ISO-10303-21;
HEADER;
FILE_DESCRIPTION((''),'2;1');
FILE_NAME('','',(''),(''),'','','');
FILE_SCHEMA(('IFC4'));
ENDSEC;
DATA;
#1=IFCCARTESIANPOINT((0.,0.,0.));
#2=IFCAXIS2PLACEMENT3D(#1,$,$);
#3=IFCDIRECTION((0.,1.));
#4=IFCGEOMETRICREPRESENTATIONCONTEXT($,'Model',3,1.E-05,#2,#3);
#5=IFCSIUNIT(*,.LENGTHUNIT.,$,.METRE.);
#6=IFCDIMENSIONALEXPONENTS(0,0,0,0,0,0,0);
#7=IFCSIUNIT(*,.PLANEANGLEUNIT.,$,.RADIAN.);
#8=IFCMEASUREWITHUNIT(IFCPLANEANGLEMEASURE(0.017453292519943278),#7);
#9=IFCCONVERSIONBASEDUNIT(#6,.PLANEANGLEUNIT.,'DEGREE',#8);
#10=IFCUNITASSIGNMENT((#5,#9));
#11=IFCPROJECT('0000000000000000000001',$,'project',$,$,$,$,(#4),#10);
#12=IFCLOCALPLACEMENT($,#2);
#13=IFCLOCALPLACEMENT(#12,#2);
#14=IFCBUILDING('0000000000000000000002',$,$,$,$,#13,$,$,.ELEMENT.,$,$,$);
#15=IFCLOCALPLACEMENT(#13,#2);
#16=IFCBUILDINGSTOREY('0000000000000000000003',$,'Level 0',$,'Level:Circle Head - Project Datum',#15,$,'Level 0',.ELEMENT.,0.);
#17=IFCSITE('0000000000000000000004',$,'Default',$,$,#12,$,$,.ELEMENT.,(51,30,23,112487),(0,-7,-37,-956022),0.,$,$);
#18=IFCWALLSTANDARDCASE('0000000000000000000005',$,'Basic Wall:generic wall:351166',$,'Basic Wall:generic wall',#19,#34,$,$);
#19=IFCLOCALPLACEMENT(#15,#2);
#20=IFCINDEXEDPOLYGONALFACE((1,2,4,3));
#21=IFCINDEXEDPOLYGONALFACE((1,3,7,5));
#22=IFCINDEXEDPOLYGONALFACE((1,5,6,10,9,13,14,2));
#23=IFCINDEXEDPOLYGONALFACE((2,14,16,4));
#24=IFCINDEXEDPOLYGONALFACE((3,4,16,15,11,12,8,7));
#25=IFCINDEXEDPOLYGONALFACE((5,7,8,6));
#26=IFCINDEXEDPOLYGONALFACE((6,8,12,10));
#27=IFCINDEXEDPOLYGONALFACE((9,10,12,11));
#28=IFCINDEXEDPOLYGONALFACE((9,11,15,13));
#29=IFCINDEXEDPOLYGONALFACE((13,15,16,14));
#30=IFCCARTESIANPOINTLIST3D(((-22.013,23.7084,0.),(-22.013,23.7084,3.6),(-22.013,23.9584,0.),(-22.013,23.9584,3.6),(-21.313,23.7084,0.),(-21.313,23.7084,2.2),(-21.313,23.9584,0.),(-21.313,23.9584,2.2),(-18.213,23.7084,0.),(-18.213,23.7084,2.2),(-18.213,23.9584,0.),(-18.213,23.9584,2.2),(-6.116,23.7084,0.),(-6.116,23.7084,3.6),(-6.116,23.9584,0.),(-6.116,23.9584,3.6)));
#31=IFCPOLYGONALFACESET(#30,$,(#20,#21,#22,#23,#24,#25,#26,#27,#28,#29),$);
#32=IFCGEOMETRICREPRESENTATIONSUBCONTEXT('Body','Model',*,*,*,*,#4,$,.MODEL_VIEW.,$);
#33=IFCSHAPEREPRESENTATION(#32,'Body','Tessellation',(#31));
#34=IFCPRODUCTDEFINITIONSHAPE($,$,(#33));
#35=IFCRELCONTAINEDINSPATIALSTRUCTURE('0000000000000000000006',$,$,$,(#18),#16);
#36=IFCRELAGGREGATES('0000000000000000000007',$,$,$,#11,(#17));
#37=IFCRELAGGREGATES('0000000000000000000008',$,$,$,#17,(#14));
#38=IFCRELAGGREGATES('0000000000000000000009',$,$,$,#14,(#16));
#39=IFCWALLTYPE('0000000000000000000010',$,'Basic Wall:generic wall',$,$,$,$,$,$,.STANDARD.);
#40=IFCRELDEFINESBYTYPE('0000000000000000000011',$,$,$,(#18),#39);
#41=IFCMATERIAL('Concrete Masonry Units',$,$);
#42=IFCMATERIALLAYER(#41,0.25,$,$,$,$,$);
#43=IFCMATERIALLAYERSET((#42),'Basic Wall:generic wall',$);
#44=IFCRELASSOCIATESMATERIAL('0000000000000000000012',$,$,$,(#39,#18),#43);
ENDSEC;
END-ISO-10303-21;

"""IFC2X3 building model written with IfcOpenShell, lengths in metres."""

from ifc_helpers import new_model, entity, si_unit, converted_unit, direction, frame, frame_2d, origin, place, context, subcontext, project, spatial, rectangle, extrude, material, layer, layer_set, layer_usage, type_object, element, save


model = new_model("IFC2X3")

# Units and contexts
model_context = context("Model", 3, precision=1e-05, world=origin(), true_north=direction((0.0, 1.0)))
body_context = subcontext(model_context, "Body", "Model", "MODEL_VIEW")
ifc_project = project(units=[si_unit("LENGTHUNIT", "METRE"), converted_unit("PLANEANGLEUNIT", "DEGREE", entity("IfcPlaneAngleMeasure", 0.017453292519943278), si_unit("PLANEANGLEUNIT", "RADIAN"), dimensions=[0, 0, 0, 0, 0, 0, 0])], contexts=[model_context])

# Site, building, storey
site_placement = place(None, origin())
site = spatial("IfcSite", under=ifc_project, at=site_placement, Name="Default", CompositionType="ELEMENT", RefLatitude=(51, 30, 23, 112487), RefLongitude=(0, -7, -37, -956022), RefElevation=0.0)
building_placement = place(site_placement, origin())
building = spatial("IfcBuilding", under=site, at=building_placement, CompositionType="ELEMENT")
storey_placement = place(building_placement, origin())
storey = spatial("IfcBuildingStorey", under=building, at=storey_placement, Name="Level 0", ObjectType="Level:Circle Head - Project Datum", LongName="Level 0", CompositionType="ELEMENT", Elevation=0.0)

# Shared definitions
ifc_material = material(Name="Concrete Masonry Units")
ifc_layer = layer(ifc_material, 0.25)
ifc_layer_set = layer_set([ifc_layer], Name="Basic Wall:generic wall")
wall_type = type_object("IfcWallType", Name="Basic Wall:generic wall", PredefinedType="STANDARD", material=ifc_layer_set)

# Wall, opening
ifc_layer_usage_1 = layer_usage(ifc_layer_set, "AXIS2", "NEGATIVE", 0.125)
wall_1_placement = place(storey_placement, frame((-6.116, 23.8334, 0.0), z_axis=(0.0, 0.0, 1.0), x_axis=(-1.0, 0.0, 0.0)))
wall_1 = element("IfcWallStandardCase", 1, at=wall_1_placement, inside=storey, type_object=wall_type, material=ifc_layer_usage_1, Name="Basic Wall:generic wall:351166", ObjectType="Basic Wall:generic wall", context=body_context, shape_type="SweptSolid", body=[
    extrude(rectangle(XDim=15.8969, YDim=0.25, at=frame_2d((7.9485, 0.0), x_axis=(-1.0, 0.0))), origin(), (0.0, 0.0, 1.0), 3.6),
])
opening_1_placement = place(wall_1_placement, frame((15.1969, 0.125, 0.0)))
element("IfcOpeningElement", 2, at=opening_1_placement, cuts=wall_1, ObjectType="Opening", context=body_context, shape_type="SweptSolid", body=[
    extrude(rectangle(XDim=2.2, YDim=3.1, at=frame_2d((1.1, 1.55), x_axis=(1.0, 0.0))), frame((0.0, 0.0, 0.0), z_axis=(0.0, -1.0, 0.0), x_axis=(0.0, 0.0, 1.0)), (0.0, 0.0, 1.0), 0.25),
])

save(model, "model.ifc")
